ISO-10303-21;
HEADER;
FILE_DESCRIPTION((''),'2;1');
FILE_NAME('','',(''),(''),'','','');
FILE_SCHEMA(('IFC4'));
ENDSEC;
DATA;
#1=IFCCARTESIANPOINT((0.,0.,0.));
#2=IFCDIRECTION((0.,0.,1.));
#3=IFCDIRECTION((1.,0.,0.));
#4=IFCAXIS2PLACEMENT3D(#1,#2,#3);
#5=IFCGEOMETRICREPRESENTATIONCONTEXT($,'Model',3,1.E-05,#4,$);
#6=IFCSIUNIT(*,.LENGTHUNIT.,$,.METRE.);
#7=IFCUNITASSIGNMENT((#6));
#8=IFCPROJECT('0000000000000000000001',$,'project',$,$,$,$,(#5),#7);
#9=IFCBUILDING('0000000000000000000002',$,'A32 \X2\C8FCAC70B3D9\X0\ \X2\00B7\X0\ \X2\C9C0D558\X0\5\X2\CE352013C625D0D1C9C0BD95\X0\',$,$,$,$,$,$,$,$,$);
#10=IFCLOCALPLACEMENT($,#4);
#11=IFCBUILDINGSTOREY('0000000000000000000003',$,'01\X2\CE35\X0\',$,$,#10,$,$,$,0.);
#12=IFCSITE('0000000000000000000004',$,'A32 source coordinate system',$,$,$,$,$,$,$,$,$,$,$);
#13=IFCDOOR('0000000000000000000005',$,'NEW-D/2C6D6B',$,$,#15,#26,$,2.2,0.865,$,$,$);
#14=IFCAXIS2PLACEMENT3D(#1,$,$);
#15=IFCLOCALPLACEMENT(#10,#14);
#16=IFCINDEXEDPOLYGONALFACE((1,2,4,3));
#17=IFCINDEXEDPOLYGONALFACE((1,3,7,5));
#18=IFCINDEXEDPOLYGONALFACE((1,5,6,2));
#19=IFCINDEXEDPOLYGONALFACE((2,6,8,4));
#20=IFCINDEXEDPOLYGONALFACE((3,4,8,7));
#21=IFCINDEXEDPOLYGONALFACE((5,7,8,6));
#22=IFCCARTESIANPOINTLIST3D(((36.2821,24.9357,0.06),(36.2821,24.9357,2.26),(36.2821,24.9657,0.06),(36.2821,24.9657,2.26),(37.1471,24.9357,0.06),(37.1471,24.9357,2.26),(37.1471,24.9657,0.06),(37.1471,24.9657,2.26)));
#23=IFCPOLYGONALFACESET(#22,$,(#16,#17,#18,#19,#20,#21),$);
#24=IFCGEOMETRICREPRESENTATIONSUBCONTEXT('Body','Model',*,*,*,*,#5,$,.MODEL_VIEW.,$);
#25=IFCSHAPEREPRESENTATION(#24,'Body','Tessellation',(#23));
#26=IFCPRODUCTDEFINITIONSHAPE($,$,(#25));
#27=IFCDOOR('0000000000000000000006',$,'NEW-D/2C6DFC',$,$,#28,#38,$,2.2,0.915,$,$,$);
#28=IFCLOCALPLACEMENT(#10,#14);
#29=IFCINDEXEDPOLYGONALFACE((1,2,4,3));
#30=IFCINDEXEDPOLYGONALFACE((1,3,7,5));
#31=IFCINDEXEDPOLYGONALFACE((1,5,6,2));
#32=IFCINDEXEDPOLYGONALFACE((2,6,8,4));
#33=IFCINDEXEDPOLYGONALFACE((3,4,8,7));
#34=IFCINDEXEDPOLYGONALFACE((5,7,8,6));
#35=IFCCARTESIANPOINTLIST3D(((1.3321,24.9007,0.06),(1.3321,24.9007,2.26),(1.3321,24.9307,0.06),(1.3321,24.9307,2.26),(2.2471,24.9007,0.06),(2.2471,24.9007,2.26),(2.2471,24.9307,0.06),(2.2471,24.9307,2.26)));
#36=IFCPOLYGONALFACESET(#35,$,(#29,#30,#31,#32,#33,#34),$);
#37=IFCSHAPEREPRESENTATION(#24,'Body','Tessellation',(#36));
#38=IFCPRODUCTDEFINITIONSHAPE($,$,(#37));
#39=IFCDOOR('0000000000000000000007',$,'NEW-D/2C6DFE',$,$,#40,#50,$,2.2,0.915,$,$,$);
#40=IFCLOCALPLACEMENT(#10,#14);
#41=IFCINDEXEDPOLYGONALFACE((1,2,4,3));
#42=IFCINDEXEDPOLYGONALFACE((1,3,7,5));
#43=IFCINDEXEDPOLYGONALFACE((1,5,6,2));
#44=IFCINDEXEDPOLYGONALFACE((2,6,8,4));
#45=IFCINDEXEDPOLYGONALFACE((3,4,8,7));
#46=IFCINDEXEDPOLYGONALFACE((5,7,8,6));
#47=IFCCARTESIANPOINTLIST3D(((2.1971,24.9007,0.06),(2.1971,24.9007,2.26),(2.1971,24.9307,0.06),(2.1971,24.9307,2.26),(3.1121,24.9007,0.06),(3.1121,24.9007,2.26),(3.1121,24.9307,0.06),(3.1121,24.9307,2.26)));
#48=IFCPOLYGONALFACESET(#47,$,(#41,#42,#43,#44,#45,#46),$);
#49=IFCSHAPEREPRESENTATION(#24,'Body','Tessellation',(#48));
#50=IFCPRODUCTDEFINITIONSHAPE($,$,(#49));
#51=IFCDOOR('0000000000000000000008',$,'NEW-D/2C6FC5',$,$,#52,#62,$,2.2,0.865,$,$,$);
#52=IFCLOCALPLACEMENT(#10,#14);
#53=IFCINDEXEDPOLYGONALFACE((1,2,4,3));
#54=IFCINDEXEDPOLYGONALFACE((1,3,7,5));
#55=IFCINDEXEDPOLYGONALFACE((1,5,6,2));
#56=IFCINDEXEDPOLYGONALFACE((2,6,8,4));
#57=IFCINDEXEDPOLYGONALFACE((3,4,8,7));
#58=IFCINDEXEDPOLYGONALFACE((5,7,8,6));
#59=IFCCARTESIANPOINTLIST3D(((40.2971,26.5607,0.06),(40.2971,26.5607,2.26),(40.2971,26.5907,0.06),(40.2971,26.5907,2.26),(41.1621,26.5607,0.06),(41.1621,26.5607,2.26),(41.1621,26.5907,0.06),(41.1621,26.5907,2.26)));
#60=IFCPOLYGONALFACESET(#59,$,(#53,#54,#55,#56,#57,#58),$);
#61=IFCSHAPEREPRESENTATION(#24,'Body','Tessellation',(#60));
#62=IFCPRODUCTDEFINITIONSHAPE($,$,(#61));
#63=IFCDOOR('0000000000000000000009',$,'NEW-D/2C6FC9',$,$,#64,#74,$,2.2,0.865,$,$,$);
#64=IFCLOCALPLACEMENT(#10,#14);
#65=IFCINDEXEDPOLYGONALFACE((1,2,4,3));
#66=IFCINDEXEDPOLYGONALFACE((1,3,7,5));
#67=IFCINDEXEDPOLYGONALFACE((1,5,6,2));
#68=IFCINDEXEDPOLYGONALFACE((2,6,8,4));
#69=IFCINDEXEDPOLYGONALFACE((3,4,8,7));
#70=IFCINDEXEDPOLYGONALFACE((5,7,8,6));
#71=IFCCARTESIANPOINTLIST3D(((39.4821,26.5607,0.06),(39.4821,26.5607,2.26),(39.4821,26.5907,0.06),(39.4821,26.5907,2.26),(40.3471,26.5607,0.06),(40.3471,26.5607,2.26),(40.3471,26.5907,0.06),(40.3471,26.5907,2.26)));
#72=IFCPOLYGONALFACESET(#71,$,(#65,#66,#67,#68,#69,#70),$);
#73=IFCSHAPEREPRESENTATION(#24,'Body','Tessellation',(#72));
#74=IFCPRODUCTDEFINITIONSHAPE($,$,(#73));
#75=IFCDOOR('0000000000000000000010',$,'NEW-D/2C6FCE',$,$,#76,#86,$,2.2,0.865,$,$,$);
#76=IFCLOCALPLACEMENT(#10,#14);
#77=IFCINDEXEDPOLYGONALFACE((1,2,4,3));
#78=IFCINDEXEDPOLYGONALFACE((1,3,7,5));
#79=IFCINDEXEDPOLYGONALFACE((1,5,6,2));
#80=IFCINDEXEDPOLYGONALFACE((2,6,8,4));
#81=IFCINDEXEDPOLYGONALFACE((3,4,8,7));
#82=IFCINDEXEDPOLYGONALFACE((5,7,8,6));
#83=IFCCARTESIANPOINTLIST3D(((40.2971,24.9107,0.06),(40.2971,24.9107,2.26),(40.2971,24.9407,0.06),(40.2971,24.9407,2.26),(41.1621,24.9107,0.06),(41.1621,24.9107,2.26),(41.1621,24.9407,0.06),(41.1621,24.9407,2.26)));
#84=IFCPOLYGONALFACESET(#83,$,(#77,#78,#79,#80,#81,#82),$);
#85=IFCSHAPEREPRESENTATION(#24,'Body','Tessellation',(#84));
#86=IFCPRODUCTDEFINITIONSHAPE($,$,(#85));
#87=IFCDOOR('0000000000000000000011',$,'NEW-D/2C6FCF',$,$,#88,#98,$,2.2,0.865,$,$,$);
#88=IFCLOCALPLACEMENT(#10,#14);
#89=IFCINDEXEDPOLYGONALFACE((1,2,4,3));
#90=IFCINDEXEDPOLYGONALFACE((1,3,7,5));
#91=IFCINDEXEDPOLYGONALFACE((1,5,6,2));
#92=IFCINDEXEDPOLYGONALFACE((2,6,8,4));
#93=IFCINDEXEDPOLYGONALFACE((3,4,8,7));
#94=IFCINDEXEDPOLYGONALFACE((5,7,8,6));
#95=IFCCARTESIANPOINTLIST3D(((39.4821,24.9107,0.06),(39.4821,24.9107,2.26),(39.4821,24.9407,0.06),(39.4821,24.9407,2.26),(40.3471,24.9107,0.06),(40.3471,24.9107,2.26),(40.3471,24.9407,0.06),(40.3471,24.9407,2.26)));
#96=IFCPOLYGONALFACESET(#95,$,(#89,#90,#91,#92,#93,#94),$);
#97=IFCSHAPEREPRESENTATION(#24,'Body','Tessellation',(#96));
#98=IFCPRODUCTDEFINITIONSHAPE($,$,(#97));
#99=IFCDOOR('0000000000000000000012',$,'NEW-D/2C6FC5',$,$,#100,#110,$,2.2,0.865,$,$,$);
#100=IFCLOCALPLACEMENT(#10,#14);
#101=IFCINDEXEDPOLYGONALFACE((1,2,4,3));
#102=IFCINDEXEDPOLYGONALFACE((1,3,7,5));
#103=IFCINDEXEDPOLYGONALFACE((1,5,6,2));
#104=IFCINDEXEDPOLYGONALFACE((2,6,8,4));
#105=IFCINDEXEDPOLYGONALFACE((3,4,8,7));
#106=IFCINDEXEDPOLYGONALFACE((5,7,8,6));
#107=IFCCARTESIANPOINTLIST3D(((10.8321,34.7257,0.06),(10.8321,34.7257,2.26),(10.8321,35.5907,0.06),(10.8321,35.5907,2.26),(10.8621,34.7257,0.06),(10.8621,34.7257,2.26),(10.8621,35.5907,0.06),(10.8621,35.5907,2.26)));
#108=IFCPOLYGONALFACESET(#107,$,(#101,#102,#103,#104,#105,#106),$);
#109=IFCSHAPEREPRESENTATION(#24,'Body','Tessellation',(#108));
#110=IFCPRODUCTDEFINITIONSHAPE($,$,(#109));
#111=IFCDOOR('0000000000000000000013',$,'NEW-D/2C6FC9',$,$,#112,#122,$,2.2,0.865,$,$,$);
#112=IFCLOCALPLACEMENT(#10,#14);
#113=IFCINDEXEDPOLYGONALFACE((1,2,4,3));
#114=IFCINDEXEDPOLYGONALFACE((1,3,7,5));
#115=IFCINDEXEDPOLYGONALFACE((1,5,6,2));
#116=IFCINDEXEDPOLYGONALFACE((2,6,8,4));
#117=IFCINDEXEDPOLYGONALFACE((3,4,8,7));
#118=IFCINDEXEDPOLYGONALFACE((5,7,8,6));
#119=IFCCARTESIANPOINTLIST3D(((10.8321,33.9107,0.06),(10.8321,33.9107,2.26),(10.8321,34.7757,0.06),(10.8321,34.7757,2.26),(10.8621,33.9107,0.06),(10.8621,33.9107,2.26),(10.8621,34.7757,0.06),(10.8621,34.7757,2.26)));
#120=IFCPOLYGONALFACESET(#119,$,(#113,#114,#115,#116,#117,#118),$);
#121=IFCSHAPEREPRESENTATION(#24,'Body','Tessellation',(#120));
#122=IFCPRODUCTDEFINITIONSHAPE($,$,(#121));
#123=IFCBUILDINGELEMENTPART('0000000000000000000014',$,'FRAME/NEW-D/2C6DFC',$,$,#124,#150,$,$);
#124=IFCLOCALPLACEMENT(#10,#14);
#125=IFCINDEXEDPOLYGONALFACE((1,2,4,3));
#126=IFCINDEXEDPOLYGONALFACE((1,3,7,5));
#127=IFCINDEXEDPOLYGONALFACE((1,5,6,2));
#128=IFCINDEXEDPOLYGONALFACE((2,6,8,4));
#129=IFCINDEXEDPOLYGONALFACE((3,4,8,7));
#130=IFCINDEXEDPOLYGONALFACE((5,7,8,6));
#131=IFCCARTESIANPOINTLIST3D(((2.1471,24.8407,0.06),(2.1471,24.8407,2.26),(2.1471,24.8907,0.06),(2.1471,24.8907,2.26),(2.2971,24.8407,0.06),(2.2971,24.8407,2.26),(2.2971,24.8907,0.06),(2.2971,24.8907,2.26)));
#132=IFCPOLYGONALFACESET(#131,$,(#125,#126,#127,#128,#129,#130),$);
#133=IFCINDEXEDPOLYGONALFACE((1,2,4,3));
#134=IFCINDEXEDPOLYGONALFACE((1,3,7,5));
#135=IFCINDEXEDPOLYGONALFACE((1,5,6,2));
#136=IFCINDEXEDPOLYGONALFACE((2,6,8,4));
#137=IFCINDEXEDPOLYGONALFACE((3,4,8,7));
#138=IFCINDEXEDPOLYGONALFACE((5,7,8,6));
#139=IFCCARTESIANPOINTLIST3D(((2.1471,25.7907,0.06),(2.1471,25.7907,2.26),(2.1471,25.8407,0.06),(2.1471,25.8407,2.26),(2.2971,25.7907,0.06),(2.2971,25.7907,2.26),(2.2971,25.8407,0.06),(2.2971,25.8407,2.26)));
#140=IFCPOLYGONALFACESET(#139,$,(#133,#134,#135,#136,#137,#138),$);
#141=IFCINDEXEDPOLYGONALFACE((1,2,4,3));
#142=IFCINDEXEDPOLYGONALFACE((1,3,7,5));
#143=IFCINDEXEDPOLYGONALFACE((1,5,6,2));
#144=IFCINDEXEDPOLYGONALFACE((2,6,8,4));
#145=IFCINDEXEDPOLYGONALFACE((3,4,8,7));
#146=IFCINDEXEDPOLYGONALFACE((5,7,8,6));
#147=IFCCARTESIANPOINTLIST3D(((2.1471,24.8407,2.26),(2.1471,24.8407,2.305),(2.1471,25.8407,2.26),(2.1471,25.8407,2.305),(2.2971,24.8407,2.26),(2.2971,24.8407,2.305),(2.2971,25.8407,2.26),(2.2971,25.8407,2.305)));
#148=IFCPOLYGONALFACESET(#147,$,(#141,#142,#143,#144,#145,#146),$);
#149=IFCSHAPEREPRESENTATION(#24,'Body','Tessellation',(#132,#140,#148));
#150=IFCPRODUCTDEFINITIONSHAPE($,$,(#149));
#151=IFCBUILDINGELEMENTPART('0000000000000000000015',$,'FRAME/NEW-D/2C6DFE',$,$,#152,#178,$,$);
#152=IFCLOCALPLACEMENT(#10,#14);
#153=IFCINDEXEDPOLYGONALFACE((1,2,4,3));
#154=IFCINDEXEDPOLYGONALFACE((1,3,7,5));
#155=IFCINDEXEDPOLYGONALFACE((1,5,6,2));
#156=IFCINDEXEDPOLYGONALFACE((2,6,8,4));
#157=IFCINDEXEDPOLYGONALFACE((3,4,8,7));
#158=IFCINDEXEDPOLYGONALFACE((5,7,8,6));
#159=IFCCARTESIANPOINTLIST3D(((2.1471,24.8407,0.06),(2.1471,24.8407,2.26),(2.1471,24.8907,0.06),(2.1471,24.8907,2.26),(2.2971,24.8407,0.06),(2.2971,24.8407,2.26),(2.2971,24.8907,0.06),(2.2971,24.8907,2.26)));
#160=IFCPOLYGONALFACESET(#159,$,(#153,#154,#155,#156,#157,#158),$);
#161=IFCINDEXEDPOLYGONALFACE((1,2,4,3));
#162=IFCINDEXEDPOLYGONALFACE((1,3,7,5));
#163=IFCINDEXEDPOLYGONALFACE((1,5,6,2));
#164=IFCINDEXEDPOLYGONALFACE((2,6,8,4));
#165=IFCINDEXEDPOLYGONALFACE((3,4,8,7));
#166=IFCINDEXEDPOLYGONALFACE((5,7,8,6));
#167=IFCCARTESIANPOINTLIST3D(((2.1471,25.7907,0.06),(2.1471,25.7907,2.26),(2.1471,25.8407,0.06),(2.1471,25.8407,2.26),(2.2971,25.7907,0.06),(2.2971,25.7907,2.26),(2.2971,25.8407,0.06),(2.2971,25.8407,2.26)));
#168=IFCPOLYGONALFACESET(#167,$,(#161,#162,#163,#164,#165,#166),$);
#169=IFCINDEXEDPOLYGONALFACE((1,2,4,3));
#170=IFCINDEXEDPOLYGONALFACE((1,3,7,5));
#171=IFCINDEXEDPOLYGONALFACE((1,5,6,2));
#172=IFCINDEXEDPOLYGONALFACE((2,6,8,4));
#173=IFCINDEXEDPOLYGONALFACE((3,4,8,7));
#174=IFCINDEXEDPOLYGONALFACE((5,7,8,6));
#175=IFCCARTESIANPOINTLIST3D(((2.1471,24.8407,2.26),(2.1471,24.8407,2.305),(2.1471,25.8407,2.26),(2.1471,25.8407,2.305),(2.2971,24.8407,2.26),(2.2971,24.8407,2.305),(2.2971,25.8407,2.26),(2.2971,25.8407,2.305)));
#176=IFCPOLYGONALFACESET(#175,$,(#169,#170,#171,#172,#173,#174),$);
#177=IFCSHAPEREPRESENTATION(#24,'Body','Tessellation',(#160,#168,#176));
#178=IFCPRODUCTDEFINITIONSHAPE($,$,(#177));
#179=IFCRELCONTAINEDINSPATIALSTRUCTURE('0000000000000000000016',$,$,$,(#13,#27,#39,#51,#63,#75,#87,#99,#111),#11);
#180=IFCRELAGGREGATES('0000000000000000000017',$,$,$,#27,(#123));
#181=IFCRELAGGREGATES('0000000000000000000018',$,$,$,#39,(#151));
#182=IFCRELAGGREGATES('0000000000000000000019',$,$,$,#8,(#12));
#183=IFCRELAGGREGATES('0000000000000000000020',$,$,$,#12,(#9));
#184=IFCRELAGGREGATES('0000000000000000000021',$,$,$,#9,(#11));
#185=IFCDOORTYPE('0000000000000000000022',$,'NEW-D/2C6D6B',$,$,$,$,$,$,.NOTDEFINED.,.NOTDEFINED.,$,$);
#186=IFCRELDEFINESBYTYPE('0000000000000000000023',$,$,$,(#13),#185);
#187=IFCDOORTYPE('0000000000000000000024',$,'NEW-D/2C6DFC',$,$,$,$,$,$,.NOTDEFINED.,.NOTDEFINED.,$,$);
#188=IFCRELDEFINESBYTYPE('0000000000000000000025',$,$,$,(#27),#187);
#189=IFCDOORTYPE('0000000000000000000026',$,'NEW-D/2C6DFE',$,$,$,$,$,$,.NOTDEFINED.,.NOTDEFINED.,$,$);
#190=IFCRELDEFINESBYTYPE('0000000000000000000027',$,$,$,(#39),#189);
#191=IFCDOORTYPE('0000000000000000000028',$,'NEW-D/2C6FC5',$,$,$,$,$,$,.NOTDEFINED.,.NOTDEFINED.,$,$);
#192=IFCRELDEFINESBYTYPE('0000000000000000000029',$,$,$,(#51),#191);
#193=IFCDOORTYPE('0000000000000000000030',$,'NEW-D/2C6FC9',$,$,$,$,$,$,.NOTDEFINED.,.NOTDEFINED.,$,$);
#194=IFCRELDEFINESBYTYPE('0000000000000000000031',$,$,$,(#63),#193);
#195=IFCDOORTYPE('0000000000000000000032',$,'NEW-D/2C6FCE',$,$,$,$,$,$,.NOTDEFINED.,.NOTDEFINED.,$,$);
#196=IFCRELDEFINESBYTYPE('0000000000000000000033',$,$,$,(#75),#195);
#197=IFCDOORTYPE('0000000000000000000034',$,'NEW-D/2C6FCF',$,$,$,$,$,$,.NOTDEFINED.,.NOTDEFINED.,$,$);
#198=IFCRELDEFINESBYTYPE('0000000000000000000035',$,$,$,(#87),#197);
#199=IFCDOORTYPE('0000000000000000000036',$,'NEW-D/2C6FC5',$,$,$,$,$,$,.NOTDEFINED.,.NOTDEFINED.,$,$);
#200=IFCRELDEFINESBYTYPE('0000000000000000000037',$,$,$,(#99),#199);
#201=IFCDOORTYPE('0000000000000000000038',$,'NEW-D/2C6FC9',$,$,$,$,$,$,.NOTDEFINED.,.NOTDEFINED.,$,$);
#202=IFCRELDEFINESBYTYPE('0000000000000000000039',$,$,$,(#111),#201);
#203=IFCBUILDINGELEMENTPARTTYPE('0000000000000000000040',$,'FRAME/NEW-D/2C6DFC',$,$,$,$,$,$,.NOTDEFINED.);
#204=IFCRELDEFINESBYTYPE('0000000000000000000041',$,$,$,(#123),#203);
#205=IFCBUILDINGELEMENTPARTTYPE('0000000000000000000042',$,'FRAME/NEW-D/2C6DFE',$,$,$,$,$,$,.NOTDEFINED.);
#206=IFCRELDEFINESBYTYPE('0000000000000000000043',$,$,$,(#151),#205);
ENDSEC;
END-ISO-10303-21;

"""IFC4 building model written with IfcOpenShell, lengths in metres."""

from ifc_helpers import new_model, si_unit, frame, origin, origin_with_axes, place, context, subcontext, project, spatial, polyline, outline, extrude, source, transform, mapped, type_object, type_shapes, element, aggregate, save


model = new_model("IFC4")

# Units and contexts
model_context = context("Model", 3, precision=1e-05, world=origin_with_axes())
body_context = subcontext(model_context, "Body", "Model", "MODEL_VIEW")
ifc_project = project(units=[si_unit("LENGTHUNIT", "METRE")], contexts=[model_context])

# Site, building, storey
storey_placement = place(None, origin_with_axes())
site = spatial("IfcSite", under=ifc_project, Name="A32 source coordinate system")
building = spatial("IfcBuilding", under=site, Name="A32 주거동 · 지하5층–옥탑지붕")
storey = spatial("IfcBuildingStorey", under=building, at=storey_placement, Name="01층", Elevation=0.0)

# Door
door_type_1 = type_object("IfcDoorType", Name="NEW-D/2C6D6B", OperationType="NOTDEFINED", PredefinedType="NOTDEFINED")
shared_shape_1 = source(origin(), body_context, "Body", "SweptSolid", [
    extrude(outline(polyline([(36.2821, 24.9357), (36.2821, 24.9657), (37.1471, 24.9657), (37.1471, 24.9357), (36.2821, 24.9357)])), frame((0.0, 0.0, 0.06)), (0.0, 0.0, 1.0), 2.2),
])
type_shapes(door_type_1, [shared_shape_1])
door_1_placement = place(storey_placement, origin_with_axes())
element("IfcDoor", 1, at=door_1_placement, inside=storey, type_object=door_type_1, Name="NEW-D/2C6D6B", OverallHeight=2.2, OverallWidth=0.865, context=body_context, shape_type="MappedRepresentation", body=[
    mapped(shared_shape_1, transform((0.0, 0.0, 0.0), scale=1.0)),
])

# Doors
door_type_2 = type_object("IfcDoorType", Name="NEW-D/2C6DFC", OperationType="NOTDEFINED", PredefinedType="NOTDEFINED")
shared_shape_2 = source(origin(), body_context, "Body", "SweptSolid", [
    extrude(outline(polyline([(1.3321, 24.9007), (1.3321, 24.9307), (2.2471, 24.9307), (2.2471, 24.9007), (1.3321, 24.9007)])), frame((0.0, 0.0, 0.06)), (0.0, 0.0, 1.0), 2.2),
])
type_shapes(door_type_2, [shared_shape_2])
door_2_placement = place(storey_placement, origin_with_axes())
door_2 = element("IfcDoor", 2, at=door_2_placement, inside=storey, type_object=door_type_2, Name="NEW-D/2C6DFC", OverallHeight=2.2, OverallWidth=0.915, context=body_context, shape_type="MappedRepresentation", body=[
    mapped(shared_shape_2, transform((0.0, 0.0, 0.0), scale=1.0)),
])
door_type_3 = type_object("IfcDoorType", Name="NEW-D/2C6DFE", OperationType="NOTDEFINED", PredefinedType="NOTDEFINED")
shared_shape_3 = source(origin(), body_context, "Body", "SweptSolid", [
    extrude(outline(polyline([(2.1971, 24.9307), (3.1121, 24.9307), (3.1121, 24.9007), (2.1971, 24.9007), (2.1971, 24.9307)])), frame((0.0, 0.0, 0.06)), (0.0, 0.0, 1.0), 2.2),
])
type_shapes(door_type_3, [shared_shape_3])
door_3_placement = place(storey_placement, origin_with_axes())
door_3 = element("IfcDoor", 3, at=door_3_placement, inside=storey, type_object=door_type_3, Name="NEW-D/2C6DFE", OverallHeight=2.2, OverallWidth=0.915, context=body_context, shape_type="MappedRepresentation", body=[
    mapped(shared_shape_3, transform((0.0, 0.0, 0.0), scale=1.0)),
])

# Doors
door_type_4 = type_object("IfcDoorType", Name="NEW-D/2C6FC5", OperationType="NOTDEFINED", PredefinedType="NOTDEFINED")
shared_shape_4 = source(origin(), body_context, "Body", "SweptSolid", [
    extrude(outline(polyline([(41.1621, 26.5907), (41.1621, 26.5607), (40.2971, 26.5607), (40.2971, 26.5907), (41.1621, 26.5907)])), frame((0.0, 0.0, 0.06)), (0.0, 0.0, 1.0), 2.2),
])
type_shapes(door_type_4, [shared_shape_4])
door_4_placement = place(storey_placement, origin_with_axes())
element("IfcDoor", 4, at=door_4_placement, inside=storey, type_object=door_type_4, Name="NEW-D/2C6FC5", OverallHeight=2.2, OverallWidth=0.865, context=body_context, shape_type="MappedRepresentation", body=[
    mapped(shared_shape_4, transform((0.0, 0.0, 0.0), scale=1.0)),
])
door_type_5 = type_object("IfcDoorType", Name="NEW-D/2C6FC9", OperationType="NOTDEFINED", PredefinedType="NOTDEFINED")
shared_shape_5 = source(origin(), body_context, "Body", "SweptSolid", [
    extrude(outline(polyline([(40.3471, 26.5607), (39.4821, 26.5607), (39.4821, 26.5907), (40.3471, 26.5907), (40.3471, 26.5607)])), frame((0.0, 0.0, 0.06)), (0.0, 0.0, 1.0), 2.2),
])
type_shapes(door_type_5, [shared_shape_5])
door_5_placement = place(storey_placement, origin_with_axes())
element("IfcDoor", 5, at=door_5_placement, inside=storey, type_object=door_type_5, Name="NEW-D/2C6FC9", OverallHeight=2.2, OverallWidth=0.865, context=body_context, shape_type="MappedRepresentation", body=[
    mapped(shared_shape_5, transform((0.0, 0.0, 0.0), scale=1.0)),
])
door_type_6 = type_object("IfcDoorType", Name="NEW-D/2C6FCE", OperationType="NOTDEFINED", PredefinedType="NOTDEFINED")
shared_shape_6 = source(origin(), body_context, "Body", "SweptSolid", [
    extrude(outline(polyline([(40.2971, 24.9407), (41.1621, 24.9407), (41.1621, 24.9107), (40.2971, 24.9107), (40.2971, 24.9407)])), frame((0.0, 0.0, 0.06)), (0.0, 0.0, 1.0), 2.2),
])
type_shapes(door_type_6, [shared_shape_6])
door_6_placement = place(storey_placement, origin_with_axes())
element("IfcDoor", 6, at=door_6_placement, inside=storey, type_object=door_type_6, Name="NEW-D/2C6FCE", OverallHeight=2.2, OverallWidth=0.865, context=body_context, shape_type="MappedRepresentation", body=[
    mapped(shared_shape_6, transform((0.0, 0.0, 0.0), scale=1.0)),
])
door_type_7 = type_object("IfcDoorType", Name="NEW-D/2C6FCF", OperationType="NOTDEFINED", PredefinedType="NOTDEFINED")
shared_shape_7 = source(origin(), body_context, "Body", "SweptSolid", [
    extrude(outline(polyline([(39.4821, 24.9107), (39.4821, 24.9407), (40.3471, 24.9407), (40.3471, 24.9107), (39.4821, 24.9107)])), frame((0.0, 0.0, 0.06)), (0.0, 0.0, 1.0), 2.2),
])
type_shapes(door_type_7, [shared_shape_7])
door_7_placement = place(storey_placement, origin_with_axes())
element("IfcDoor", 7, at=door_7_placement, inside=storey, type_object=door_type_7, Name="NEW-D/2C6FCF", OverallHeight=2.2, OverallWidth=0.865, context=body_context, shape_type="MappedRepresentation", body=[
    mapped(shared_shape_7, transform((0.0, 0.0, 0.0), scale=1.0)),
])
door_type_8 = type_object("IfcDoorType", Name="NEW-D/2C6FC5", OperationType="NOTDEFINED", PredefinedType="NOTDEFINED")
shared_shape_8 = source(origin(), body_context, "Body", "SweptSolid", [
    extrude(outline(polyline([(10.8321, 34.7257), (10.8321, 35.5907), (10.8621, 35.5907), (10.8621, 34.7257), (10.8321, 34.7257)])), frame((0.0, 0.0, 0.06)), (0.0, 0.0, 1.0), 2.2),
])
type_shapes(door_type_8, [shared_shape_8])
door_8_placement = place(storey_placement, origin_with_axes())
element("IfcDoor", 8, at=door_8_placement, inside=storey, type_object=door_type_8, Name="NEW-D/2C6FC5", OverallHeight=2.2, OverallWidth=0.865, context=body_context, shape_type="MappedRepresentation", body=[
    mapped(shared_shape_8, transform((0.0, 0.0, 0.0), scale=1.0)),
])
door_type_9 = type_object("IfcDoorType", Name="NEW-D/2C6FC9", OperationType="NOTDEFINED", PredefinedType="NOTDEFINED")
shared_shape_9 = source(origin(), body_context, "Body", "SweptSolid", [
    extrude(outline(polyline([(10.8621, 33.9107), (10.8321, 33.9107), (10.8321, 34.7757), (10.8621, 34.7757), (10.8621, 33.9107)])), frame((0.0, 0.0, 0.06)), (0.0, 0.0, 1.0), 2.2),
])
type_shapes(door_type_9, [shared_shape_9])
door_9_placement = place(storey_placement, origin_with_axes())
element("IfcDoor", 9, at=door_9_placement, inside=storey, type_object=door_type_9, Name="NEW-D/2C6FC9", OverallHeight=2.2, OverallWidth=0.865, context=body_context, shape_type="MappedRepresentation", body=[
    mapped(shared_shape_9, transform((0.0, 0.0, 0.0), scale=1.0)),
])

# Building element parts
building_element_part_type_1 = type_object("IfcBuildingElementPartType", Name="FRAME/NEW-D/2C6DFC", PredefinedType="NOTDEFINED")
shared_shape_10 = source(origin(), body_context, "Body", "SweptSolid", [
    extrude(outline(polyline([(2.2971, 24.8907), (2.2971, 24.8407), (2.1471, 24.8407), (2.1471, 24.8907), (2.2971, 24.8907)])), frame((0.0, 0.0, 0.06)), (0.0, 0.0, 1.0), 2.2),
    extrude(outline(polyline([(2.2971, 25.8407), (2.2971, 25.7907), (2.1471, 25.7907), (2.1471, 25.8407), (2.2971, 25.8407)])), frame((0.0, 0.0, 0.06)), (0.0, 0.0, 1.0), 2.2),
    extrude(outline(polyline([(2.2971, 24.8407), (2.2971, 25.8407), (2.1471, 25.8407), (2.1471, 24.8407), (2.2971, 24.8407)])), frame((0.0, 0.0, 2.26)), (0.0, 0.0, 1.0), 0.045),
])
type_shapes(building_element_part_type_1, [shared_shape_10])
building_element_part_1_placement = place(door_2_placement, origin_with_axes())
building_element_part_1 = element("IfcBuildingElementPart", 10, at=building_element_part_1_placement, type_object=building_element_part_type_1, Name="FRAME/NEW-D/2C6DFC", context=body_context, shape_type="MappedRepresentation", body=[
    mapped(shared_shape_10, transform((0.0, 0.0, 0.0), scale=1.0)),
])
aggregate(door_2, [building_element_part_1])
building_element_part_type_2 = type_object("IfcBuildingElementPartType", Name="FRAME/NEW-D/2C6DFE", PredefinedType="NOTDEFINED")
shared_shape_11 = source(origin(), body_context, "Body", "SweptSolid", [
    extrude(outline(polyline([(2.2971, 24.8907), (2.2971, 24.8407), (2.1471, 24.8407), (2.1471, 24.8907), (2.2971, 24.8907)])), frame((0.0, 0.0, 0.06)), (0.0, 0.0, 1.0), 2.2),
    extrude(outline(polyline([(2.2971, 25.8407), (2.2971, 25.7907), (2.1471, 25.7907), (2.1471, 25.8407), (2.2971, 25.8407)])), frame((0.0, 0.0, 0.06)), (0.0, 0.0, 1.0), 2.2),
    extrude(outline(polyline([(2.2971, 24.8407), (2.2971, 25.8407), (2.1471, 25.8407), (2.1471, 24.8407), (2.2971, 24.8407)])), frame((0.0, 0.0, 2.26)), (0.0, 0.0, 1.0), 0.045),
])
type_shapes(building_element_part_type_2, [shared_shape_11])
building_element_part_2_placement = place(door_3_placement, origin_with_axes())
building_element_part_2 = element("IfcBuildingElementPart", 11, at=building_element_part_2_placement, type_object=building_element_part_type_2, Name="FRAME/NEW-D/2C6DFE", context=body_context, shape_type="MappedRepresentation", body=[
    mapped(shared_shape_11, transform((0.0, 0.0, 0.0), scale=1.0)),
])
aggregate(door_3, [building_element_part_2])

save(model, "model.ifc")
